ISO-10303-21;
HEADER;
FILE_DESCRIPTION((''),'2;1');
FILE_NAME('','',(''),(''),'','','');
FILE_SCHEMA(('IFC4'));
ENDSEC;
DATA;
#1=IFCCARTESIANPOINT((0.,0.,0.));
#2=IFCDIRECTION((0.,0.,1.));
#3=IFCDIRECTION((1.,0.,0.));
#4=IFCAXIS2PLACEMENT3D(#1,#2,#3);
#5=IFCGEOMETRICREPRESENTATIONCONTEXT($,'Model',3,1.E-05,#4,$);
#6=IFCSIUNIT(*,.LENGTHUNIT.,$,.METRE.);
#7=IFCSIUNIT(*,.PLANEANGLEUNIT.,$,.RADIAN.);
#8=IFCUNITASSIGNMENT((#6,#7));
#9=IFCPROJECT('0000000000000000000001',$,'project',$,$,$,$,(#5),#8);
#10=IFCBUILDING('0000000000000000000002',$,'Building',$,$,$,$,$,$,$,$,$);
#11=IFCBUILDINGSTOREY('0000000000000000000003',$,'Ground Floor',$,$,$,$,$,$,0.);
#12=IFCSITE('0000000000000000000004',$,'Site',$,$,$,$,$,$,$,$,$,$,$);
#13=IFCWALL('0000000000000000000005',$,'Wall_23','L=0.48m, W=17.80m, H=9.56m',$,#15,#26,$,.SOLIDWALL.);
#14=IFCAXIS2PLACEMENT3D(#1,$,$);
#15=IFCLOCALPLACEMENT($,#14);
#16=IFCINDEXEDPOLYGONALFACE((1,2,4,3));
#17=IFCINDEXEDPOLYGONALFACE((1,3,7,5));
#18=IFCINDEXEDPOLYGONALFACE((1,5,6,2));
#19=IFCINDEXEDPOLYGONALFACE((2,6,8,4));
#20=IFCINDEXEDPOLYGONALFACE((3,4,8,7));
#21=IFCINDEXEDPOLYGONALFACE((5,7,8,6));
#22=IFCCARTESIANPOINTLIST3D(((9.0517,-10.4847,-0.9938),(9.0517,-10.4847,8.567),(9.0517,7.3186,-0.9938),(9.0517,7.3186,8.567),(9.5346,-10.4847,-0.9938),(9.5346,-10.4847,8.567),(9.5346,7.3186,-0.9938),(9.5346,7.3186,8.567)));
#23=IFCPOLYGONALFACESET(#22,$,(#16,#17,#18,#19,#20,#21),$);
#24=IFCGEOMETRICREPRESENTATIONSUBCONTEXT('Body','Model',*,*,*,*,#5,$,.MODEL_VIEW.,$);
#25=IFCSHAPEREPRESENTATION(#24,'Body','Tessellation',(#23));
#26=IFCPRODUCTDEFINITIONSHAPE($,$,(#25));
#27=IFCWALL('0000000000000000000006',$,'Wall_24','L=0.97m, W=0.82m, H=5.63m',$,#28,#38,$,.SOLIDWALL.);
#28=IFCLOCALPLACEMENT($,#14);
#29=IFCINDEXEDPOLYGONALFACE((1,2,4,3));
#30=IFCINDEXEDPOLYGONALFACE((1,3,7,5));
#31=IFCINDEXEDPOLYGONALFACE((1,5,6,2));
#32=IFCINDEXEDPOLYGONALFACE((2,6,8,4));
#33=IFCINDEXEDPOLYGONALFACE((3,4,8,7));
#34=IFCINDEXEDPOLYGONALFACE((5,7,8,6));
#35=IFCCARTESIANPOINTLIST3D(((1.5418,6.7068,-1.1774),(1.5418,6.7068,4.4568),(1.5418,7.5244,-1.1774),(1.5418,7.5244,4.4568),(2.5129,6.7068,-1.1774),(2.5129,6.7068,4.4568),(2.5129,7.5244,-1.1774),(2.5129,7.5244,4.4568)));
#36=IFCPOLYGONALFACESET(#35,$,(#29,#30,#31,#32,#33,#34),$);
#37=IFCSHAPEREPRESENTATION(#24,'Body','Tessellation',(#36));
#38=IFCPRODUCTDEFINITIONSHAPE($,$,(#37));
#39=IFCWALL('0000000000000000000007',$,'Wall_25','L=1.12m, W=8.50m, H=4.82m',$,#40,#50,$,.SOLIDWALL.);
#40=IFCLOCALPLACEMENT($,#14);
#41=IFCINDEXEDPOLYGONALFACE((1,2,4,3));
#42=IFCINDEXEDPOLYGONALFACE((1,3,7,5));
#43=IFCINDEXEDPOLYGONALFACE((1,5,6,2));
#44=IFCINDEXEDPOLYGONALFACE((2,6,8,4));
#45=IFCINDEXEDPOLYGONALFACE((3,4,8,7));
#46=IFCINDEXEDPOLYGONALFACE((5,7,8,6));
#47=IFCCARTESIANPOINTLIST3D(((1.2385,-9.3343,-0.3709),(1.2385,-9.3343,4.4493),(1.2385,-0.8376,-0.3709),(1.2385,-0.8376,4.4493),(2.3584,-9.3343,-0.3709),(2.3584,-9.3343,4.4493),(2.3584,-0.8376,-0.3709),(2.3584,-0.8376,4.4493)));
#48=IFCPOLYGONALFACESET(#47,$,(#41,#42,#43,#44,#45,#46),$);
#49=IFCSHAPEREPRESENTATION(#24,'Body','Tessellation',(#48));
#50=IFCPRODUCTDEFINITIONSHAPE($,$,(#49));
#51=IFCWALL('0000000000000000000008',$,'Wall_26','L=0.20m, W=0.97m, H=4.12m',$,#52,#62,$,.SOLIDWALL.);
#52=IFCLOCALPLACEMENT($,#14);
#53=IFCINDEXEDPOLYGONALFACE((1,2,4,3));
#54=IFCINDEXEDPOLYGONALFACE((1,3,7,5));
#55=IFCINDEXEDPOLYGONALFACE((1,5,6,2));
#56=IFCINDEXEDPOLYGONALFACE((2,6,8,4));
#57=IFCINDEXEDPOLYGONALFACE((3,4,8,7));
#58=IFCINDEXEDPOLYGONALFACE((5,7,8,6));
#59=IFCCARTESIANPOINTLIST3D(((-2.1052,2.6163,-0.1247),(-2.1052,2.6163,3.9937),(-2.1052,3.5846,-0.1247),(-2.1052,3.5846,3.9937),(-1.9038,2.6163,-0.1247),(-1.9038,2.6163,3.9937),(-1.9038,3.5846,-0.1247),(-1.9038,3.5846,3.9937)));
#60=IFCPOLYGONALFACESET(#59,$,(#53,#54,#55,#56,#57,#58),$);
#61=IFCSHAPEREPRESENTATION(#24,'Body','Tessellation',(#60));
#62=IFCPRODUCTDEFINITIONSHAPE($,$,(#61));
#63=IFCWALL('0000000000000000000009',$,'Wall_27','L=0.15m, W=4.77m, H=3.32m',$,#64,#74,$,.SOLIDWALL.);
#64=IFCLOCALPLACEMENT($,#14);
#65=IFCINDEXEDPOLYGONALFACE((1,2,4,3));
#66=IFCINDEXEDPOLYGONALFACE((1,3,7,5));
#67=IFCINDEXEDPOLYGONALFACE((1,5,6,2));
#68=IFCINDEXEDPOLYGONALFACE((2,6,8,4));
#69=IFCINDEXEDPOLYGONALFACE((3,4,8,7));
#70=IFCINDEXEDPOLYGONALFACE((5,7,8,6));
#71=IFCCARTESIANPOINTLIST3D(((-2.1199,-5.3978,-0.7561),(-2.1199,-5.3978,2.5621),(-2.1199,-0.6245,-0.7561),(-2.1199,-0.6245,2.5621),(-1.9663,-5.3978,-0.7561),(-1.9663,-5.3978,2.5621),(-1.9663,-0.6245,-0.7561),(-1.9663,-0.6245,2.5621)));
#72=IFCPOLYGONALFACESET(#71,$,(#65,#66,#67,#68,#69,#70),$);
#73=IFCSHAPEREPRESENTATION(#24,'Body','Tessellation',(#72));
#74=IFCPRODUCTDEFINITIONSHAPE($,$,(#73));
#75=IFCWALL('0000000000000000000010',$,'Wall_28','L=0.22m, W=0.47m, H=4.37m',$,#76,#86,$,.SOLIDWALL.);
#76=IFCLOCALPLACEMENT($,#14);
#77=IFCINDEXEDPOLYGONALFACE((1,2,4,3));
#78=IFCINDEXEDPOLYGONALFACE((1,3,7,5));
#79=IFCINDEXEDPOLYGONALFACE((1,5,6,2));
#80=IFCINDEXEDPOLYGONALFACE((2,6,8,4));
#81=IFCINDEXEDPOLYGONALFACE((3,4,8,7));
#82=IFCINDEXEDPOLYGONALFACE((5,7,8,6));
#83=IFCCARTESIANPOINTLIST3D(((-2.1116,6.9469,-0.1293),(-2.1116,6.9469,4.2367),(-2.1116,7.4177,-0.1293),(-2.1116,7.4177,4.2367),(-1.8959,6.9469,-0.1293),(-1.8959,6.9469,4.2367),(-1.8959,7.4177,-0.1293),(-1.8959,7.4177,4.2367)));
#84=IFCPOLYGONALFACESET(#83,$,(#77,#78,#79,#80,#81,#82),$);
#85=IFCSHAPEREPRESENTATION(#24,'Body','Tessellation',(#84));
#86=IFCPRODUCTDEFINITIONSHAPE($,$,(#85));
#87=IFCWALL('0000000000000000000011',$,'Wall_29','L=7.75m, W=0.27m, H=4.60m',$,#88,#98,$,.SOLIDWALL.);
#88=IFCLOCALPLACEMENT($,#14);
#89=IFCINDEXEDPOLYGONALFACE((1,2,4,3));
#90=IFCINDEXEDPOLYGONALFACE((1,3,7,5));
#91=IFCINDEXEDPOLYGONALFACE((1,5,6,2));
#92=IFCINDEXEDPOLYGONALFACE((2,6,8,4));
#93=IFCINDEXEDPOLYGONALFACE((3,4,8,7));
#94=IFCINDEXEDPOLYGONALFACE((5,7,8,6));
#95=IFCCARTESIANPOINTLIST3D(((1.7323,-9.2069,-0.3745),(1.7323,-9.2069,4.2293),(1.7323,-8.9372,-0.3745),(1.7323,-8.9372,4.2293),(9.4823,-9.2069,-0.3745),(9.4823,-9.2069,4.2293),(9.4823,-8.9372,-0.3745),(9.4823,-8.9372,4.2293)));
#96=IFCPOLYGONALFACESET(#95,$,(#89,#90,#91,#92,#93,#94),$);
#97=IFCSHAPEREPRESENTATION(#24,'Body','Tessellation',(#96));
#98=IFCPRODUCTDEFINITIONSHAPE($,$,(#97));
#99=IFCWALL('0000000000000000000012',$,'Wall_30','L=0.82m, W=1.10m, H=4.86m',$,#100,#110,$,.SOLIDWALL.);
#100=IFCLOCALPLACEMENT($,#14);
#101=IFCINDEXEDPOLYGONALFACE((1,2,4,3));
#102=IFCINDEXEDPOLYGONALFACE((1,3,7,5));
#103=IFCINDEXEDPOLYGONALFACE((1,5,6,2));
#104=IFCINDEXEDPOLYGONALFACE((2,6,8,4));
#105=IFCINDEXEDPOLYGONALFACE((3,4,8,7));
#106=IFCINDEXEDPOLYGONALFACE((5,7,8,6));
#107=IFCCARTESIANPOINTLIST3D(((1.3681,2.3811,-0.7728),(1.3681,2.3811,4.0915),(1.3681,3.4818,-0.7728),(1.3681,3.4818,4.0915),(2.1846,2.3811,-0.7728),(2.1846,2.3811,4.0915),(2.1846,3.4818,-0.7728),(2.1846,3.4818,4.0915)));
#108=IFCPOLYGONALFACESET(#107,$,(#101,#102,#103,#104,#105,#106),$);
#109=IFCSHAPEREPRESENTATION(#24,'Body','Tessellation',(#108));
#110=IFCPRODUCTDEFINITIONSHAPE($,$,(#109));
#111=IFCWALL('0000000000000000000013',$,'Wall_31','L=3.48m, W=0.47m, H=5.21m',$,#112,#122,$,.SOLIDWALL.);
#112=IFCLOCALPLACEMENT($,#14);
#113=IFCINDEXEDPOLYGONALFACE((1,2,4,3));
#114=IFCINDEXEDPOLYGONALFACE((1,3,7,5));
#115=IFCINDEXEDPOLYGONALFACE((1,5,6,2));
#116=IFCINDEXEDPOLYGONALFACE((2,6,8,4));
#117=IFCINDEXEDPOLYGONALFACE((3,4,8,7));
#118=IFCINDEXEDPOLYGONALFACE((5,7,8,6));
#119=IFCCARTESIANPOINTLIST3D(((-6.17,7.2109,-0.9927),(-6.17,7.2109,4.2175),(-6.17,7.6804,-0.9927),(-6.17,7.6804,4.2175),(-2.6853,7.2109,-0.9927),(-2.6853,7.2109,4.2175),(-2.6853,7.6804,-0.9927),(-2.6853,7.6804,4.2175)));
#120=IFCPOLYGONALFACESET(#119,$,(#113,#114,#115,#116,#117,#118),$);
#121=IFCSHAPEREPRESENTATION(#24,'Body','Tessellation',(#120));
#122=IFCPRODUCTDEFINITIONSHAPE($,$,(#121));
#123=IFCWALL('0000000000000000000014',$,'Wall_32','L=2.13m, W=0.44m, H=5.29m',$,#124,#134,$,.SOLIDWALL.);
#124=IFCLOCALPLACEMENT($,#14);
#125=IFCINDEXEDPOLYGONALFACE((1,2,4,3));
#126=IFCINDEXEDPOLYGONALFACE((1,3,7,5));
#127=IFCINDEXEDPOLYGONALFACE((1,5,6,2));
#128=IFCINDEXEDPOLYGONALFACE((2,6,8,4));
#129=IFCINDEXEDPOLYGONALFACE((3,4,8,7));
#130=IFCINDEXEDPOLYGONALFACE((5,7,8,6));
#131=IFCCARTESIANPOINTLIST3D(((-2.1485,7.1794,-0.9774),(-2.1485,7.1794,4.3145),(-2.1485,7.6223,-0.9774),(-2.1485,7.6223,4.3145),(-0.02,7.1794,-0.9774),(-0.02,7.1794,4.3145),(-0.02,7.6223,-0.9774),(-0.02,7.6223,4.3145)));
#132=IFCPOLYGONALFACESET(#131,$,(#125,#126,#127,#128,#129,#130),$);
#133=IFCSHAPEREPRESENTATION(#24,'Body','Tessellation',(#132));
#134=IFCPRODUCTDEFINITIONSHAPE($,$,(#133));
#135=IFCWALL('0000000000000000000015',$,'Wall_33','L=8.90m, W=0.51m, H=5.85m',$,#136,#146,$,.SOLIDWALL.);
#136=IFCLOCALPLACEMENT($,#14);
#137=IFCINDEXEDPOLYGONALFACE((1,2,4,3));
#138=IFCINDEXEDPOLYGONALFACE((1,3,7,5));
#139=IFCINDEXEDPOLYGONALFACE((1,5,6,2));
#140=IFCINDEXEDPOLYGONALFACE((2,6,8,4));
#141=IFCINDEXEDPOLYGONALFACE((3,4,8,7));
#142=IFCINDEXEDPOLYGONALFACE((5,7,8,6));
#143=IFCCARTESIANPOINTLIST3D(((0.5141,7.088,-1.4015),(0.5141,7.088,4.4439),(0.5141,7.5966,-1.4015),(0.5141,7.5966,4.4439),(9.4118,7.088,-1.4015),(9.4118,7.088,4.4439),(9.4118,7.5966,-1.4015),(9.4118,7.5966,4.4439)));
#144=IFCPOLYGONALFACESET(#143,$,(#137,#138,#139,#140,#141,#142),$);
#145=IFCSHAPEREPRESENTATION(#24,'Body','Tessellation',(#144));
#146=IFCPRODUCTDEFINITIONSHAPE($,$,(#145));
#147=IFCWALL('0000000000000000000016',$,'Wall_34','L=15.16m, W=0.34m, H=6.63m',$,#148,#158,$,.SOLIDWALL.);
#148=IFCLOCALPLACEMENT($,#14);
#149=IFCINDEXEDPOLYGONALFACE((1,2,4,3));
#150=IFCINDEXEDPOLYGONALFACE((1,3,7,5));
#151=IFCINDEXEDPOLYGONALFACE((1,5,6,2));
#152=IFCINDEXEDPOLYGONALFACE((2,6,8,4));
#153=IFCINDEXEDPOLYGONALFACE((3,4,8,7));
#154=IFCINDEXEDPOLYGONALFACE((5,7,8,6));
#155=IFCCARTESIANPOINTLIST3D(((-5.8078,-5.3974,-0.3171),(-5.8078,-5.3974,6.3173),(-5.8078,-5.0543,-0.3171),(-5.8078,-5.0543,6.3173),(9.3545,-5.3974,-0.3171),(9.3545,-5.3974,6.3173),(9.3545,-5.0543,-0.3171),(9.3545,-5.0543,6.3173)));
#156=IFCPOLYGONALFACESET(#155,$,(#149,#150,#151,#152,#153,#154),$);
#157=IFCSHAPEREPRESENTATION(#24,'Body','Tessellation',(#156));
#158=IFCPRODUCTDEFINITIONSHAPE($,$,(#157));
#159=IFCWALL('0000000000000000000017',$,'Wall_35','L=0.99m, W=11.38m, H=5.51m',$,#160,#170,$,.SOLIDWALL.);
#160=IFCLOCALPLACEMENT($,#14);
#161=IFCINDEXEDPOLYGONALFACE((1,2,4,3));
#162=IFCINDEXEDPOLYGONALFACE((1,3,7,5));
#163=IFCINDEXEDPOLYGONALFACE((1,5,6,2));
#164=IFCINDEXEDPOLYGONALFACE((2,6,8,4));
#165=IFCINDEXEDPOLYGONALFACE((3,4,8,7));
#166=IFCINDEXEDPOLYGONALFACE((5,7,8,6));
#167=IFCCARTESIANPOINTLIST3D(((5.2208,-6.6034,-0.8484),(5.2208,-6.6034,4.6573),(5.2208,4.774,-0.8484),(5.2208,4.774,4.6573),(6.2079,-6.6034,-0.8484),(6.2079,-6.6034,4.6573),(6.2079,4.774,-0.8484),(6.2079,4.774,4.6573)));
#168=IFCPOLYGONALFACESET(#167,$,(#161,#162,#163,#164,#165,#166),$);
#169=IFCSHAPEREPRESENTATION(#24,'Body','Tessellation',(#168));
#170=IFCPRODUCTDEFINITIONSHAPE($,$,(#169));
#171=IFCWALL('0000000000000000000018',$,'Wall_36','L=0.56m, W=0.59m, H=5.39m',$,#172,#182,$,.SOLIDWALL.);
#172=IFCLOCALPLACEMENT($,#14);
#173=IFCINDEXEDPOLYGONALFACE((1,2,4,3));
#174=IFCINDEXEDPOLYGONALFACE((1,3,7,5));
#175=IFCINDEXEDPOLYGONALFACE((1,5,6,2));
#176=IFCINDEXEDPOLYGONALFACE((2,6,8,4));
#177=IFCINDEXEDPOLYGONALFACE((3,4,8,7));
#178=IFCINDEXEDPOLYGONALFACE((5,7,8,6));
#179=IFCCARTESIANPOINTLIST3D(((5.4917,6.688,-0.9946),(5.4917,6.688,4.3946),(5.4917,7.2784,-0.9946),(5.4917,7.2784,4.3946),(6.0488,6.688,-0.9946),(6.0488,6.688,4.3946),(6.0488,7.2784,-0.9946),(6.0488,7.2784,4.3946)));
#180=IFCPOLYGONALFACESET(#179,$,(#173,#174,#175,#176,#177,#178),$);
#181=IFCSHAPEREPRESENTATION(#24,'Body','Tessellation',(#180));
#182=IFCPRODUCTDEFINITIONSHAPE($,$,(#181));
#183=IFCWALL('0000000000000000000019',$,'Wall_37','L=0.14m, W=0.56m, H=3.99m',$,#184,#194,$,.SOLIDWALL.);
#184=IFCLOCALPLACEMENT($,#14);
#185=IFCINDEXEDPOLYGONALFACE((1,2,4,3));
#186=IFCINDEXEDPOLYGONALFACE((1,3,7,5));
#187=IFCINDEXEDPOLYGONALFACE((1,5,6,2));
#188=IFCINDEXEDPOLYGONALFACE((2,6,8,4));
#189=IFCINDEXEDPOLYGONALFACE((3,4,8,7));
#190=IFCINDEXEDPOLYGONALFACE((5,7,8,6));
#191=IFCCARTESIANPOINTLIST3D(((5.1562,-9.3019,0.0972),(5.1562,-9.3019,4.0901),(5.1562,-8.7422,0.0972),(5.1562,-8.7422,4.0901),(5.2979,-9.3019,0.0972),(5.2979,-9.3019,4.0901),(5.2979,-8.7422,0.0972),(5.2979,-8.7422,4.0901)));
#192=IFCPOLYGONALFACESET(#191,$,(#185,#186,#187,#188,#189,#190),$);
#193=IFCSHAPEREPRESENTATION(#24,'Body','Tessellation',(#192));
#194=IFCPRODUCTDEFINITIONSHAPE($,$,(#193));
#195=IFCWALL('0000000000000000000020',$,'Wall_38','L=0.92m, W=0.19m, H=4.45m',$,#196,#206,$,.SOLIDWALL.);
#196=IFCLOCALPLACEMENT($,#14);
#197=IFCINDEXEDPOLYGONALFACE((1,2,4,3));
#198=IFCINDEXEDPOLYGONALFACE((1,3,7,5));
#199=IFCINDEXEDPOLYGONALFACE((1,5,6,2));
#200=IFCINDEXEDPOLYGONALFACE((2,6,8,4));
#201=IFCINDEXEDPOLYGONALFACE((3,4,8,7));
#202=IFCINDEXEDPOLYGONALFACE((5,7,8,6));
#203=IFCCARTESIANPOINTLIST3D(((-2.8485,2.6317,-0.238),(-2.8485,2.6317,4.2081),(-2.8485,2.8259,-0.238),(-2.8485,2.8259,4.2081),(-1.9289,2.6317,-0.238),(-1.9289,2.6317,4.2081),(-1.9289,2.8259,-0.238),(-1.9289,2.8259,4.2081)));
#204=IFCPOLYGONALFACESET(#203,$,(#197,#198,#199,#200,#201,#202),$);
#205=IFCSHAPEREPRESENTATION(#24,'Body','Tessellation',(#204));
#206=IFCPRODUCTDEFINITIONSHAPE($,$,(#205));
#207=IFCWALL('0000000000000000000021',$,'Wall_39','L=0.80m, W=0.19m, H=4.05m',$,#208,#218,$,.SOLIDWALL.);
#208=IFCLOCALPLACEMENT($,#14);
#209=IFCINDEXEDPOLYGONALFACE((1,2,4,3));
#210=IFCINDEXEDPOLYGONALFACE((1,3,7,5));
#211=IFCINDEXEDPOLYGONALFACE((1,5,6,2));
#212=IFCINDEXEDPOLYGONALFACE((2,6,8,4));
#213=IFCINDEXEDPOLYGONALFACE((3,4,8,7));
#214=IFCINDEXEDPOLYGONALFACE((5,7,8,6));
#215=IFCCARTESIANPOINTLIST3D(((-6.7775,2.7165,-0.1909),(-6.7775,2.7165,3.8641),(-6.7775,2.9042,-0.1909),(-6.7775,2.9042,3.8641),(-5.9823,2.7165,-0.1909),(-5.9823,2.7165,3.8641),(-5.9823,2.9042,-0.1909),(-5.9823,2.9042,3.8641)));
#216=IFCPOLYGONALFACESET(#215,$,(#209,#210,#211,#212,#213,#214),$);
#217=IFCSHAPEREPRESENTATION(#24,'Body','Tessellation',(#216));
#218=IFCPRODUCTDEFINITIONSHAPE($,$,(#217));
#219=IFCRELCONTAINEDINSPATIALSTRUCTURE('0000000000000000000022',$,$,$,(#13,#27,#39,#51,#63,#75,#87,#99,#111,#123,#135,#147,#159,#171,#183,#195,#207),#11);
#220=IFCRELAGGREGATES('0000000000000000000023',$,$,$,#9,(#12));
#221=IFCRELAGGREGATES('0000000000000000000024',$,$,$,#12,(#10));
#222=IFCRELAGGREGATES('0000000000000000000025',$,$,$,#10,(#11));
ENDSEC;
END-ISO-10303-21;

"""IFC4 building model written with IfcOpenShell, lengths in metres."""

from ifc_helpers import new_model, si_unit, frame, origin_with_axes, origin_2d, context, subcontext, project, spatial, rectangle, extrude, element, save


model = new_model("IFC4")

# Units and contexts
model_context = context("Model", 3, precision=1e-05, world=origin_with_axes())
body_context = subcontext(model_context, "Body", "Model", "MODEL_VIEW")
ifc_project = project(units=[si_unit("LENGTHUNIT", "METRE"), si_unit("PLANEANGLEUNIT", "RADIAN")], contexts=[model_context])

# Site, building, storey
site = spatial("IfcSite", under=ifc_project, Name="Site")
building = spatial("IfcBuilding", under=site, Name="Building")
storey = spatial("IfcBuildingStorey", under=building, Name="Ground Floor", Elevation=0.0)

# Walls
element("IfcWall", 1, inside=storey, Name="Wall_23", Description="L=0.48m, W=17.80m, H=9.56m", PredefinedType="SOLIDWALL", context=body_context, shape_type="SweptSolid", body=[
    extrude(rectangle(XDim=0.483, YDim=17.8033, at=origin_2d()), frame((9.2931, -1.5831, -0.9938), z_axis=(0.0, 0.0, 1.0), x_axis=(1.0, 0.0, 0.0)), (0.0, 0.0, 1.0), 9.5608),
])
element("IfcWall", 2, inside=storey, Name="Wall_24", Description="L=0.97m, W=0.82m, H=5.63m", PredefinedType="SOLIDWALL", context=body_context, shape_type="SweptSolid", body=[
    extrude(rectangle(XDim=0.9711, YDim=0.8176, at=origin_2d()), frame((2.0273, 7.1156, -1.1774), z_axis=(0.0, 0.0, 1.0), x_axis=(1.0, 0.0, 0.0)), (0.0, 0.0, 1.0), 5.6342),
])
element("IfcWall", 3, inside=storey, Name="Wall_25", Description="L=1.12m, W=8.50m, H=4.82m", PredefinedType="SOLIDWALL", context=body_context, shape_type="SweptSolid", body=[
    extrude(rectangle(XDim=1.1199, YDim=8.4967, at=origin_2d()), frame((1.7984, -5.086, -0.3709), z_axis=(0.0, 0.0, 1.0), x_axis=(1.0, 0.0, 0.0)), (0.0, 0.0, 1.0), 4.8202),
])
element("IfcWall", 4, inside=storey, Name="Wall_26", Description="L=0.20m, W=0.97m, H=4.12m", PredefinedType="SOLIDWALL", context=body_context, shape_type="SweptSolid", body=[
    extrude(rectangle(XDim=0.2014, YDim=0.9684, at=origin_2d()), frame((-2.0045, 3.1005, -0.1247), z_axis=(0.0, 0.0, 1.0), x_axis=(1.0, 0.0, 0.0)), (0.0, 0.0, 1.0), 4.1184),
])
element("IfcWall", 5, inside=storey, Name="Wall_27", Description="L=0.15m, W=4.77m, H=3.32m", PredefinedType="SOLIDWALL", context=body_context, shape_type="SweptSolid", body=[
    extrude(rectangle(XDim=0.1537, YDim=4.7733, at=origin_2d()), frame((-2.0431, -3.0111, -0.7561), z_axis=(0.0, 0.0, 1.0), x_axis=(1.0, 0.0, 0.0)), (0.0, 0.0, 1.0), 3.3182),
])
element("IfcWall", 6, inside=storey, Name="Wall_28", Description="L=0.22m, W=0.47m, H=4.37m", PredefinedType="SOLIDWALL", context=body_context, shape_type="SweptSolid", body=[
    extrude(rectangle(XDim=0.2157, YDim=0.4708, at=origin_2d()), frame((-2.0037, 7.1823, -0.1293), z_axis=(0.0, 0.0, 1.0), x_axis=(1.0, 0.0, 0.0)), (0.0, 0.0, 1.0), 4.366),
])
element("IfcWall", 7, inside=storey, Name="Wall_29", Description="L=7.75m, W=0.27m, H=4.60m", PredefinedType="SOLIDWALL", context=body_context, shape_type="SweptSolid", body=[
    extrude(rectangle(XDim=7.7499, YDim=0.2697, at=origin_2d()), frame((5.6073, -9.072, -0.3745), z_axis=(0.0, 0.0, 1.0), x_axis=(1.0, 0.0, 0.0)), (0.0, 0.0, 1.0), 4.6038),
])
element("IfcWall", 8, inside=storey, Name="Wall_30", Description="L=0.82m, W=1.10m, H=4.86m", PredefinedType="SOLIDWALL", context=body_context, shape_type="SweptSolid", body=[
    extrude(rectangle(XDim=0.8165, YDim=1.1007, at=origin_2d()), frame((1.7764, 2.9314, -0.7728), z_axis=(0.0, 0.0, 1.0), x_axis=(1.0, 0.0, 0.0)), (0.0, 0.0, 1.0), 4.8643),
])
element("IfcWall", 9, inside=storey, Name="Wall_31", Description="L=3.48m, W=0.47m, H=5.21m", PredefinedType="SOLIDWALL", context=body_context, shape_type="SweptSolid", body=[
    extrude(rectangle(XDim=3.4847, YDim=0.4695, at=origin_2d()), frame((-4.4276, 7.4457, -0.9927), z_axis=(0.0, 0.0, 1.0), x_axis=(1.0, 0.0, 0.0)), (0.0, 0.0, 1.0), 5.2102),
])
element("IfcWall", 10, inside=storey, Name="Wall_32", Description="L=2.13m, W=0.44m, H=5.29m", PredefinedType="SOLIDWALL", context=body_context, shape_type="SweptSolid", body=[
    extrude(rectangle(XDim=2.1285, YDim=0.4429, at=origin_2d()), frame((-1.0842, 7.4009, -0.9774), z_axis=(0.0, 0.0, 1.0), x_axis=(1.0, 0.0, 0.0)), (0.0, 0.0, 1.0), 5.2919),
])
element("IfcWall", 11, inside=storey, Name="Wall_33", Description="L=8.90m, W=0.51m, H=5.85m", PredefinedType="SOLIDWALL", context=body_context, shape_type="SweptSolid", body=[
    extrude(rectangle(XDim=8.8977, YDim=0.5085, at=origin_2d()), frame((4.9629, 7.3423, -1.4015), z_axis=(0.0, 0.0, 1.0), x_axis=(1.0, 0.0, 0.0)), (0.0, 0.0, 1.0), 5.8454),
])
element("IfcWall", 12, inside=storey, Name="Wall_34", Description="L=15.16m, W=0.34m, H=6.63m", PredefinedType="SOLIDWALL", context=body_context, shape_type="SweptSolid", body=[
    extrude(rectangle(XDim=15.1623, YDim=0.3431, at=origin_2d()), frame((1.7733, -5.2258, -0.3171), z_axis=(0.0, 0.0, 1.0), x_axis=(1.0, 0.0, 0.0)), (0.0, 0.0, 1.0), 6.6344),
])
element("IfcWall", 13, inside=storey, Name="Wall_35", Description="L=0.99m, W=11.38m, H=5.51m", PredefinedType="SOLIDWALL", context=body_context, shape_type="SweptSolid", body=[
    extrude(rectangle(XDim=0.9872, YDim=11.3773, at=origin_2d()), frame((5.7144, -0.9147, -0.8484), z_axis=(0.0, 0.0, 1.0), x_axis=(1.0, 0.0, 0.0)), (0.0, 0.0, 1.0), 5.5057),
])
element("IfcWall", 14, inside=storey, Name="Wall_36", Description="L=0.56m, W=0.59m, H=5.39m", PredefinedType="SOLIDWALL", context=body_context, shape_type="SweptSolid", body=[
    extrude(rectangle(XDim=0.557, YDim=0.5904, at=origin_2d()), frame((5.7703, 6.9832, -0.9946), z_axis=(0.0, 0.0, 1.0), x_axis=(1.0, 0.0, 0.0)), (0.0, 0.0, 1.0), 5.3891),
])
element("IfcWall", 15, inside=storey, Name="Wall_37", Description="L=0.14m, W=0.56m, H=3.99m", PredefinedType="SOLIDWALL", context=body_context, shape_type="SweptSolid", body=[
    extrude(rectangle(XDim=0.1417, YDim=0.5597, at=origin_2d()), frame((5.227, -9.0221, 0.0972), z_axis=(0.0, 0.0, 1.0), x_axis=(1.0, 0.0, 0.0)), (0.0, 0.0, 1.0), 3.9929),
])
element("IfcWall", 16, inside=storey, Name="Wall_38", Description="L=0.92m, W=0.19m, H=4.45m", PredefinedType="SOLIDWALL", context=body_context, shape_type="SweptSolid", body=[
    extrude(rectangle(XDim=0.9196, YDim=0.1942, at=origin_2d()), frame((-2.3887, 2.7288, -0.238), z_axis=(0.0, 0.0, 1.0), x_axis=(1.0, 0.0, 0.0)), (0.0, 0.0, 1.0), 4.4461),
])
element("IfcWall", 17, inside=storey, Name="Wall_39", Description="L=0.80m, W=0.19m, H=4.05m", PredefinedType="SOLIDWALL", context=body_context, shape_type="SweptSolid", body=[
    extrude(rectangle(XDim=0.7952, YDim=0.1877, at=origin_2d()), frame((-6.3799, 2.8103, -0.1909), z_axis=(0.0, 0.0, 1.0), x_axis=(1.0, 0.0, 0.0)), (0.0, 0.0, 1.0), 4.055),
])

save(model, "model.ifc")
